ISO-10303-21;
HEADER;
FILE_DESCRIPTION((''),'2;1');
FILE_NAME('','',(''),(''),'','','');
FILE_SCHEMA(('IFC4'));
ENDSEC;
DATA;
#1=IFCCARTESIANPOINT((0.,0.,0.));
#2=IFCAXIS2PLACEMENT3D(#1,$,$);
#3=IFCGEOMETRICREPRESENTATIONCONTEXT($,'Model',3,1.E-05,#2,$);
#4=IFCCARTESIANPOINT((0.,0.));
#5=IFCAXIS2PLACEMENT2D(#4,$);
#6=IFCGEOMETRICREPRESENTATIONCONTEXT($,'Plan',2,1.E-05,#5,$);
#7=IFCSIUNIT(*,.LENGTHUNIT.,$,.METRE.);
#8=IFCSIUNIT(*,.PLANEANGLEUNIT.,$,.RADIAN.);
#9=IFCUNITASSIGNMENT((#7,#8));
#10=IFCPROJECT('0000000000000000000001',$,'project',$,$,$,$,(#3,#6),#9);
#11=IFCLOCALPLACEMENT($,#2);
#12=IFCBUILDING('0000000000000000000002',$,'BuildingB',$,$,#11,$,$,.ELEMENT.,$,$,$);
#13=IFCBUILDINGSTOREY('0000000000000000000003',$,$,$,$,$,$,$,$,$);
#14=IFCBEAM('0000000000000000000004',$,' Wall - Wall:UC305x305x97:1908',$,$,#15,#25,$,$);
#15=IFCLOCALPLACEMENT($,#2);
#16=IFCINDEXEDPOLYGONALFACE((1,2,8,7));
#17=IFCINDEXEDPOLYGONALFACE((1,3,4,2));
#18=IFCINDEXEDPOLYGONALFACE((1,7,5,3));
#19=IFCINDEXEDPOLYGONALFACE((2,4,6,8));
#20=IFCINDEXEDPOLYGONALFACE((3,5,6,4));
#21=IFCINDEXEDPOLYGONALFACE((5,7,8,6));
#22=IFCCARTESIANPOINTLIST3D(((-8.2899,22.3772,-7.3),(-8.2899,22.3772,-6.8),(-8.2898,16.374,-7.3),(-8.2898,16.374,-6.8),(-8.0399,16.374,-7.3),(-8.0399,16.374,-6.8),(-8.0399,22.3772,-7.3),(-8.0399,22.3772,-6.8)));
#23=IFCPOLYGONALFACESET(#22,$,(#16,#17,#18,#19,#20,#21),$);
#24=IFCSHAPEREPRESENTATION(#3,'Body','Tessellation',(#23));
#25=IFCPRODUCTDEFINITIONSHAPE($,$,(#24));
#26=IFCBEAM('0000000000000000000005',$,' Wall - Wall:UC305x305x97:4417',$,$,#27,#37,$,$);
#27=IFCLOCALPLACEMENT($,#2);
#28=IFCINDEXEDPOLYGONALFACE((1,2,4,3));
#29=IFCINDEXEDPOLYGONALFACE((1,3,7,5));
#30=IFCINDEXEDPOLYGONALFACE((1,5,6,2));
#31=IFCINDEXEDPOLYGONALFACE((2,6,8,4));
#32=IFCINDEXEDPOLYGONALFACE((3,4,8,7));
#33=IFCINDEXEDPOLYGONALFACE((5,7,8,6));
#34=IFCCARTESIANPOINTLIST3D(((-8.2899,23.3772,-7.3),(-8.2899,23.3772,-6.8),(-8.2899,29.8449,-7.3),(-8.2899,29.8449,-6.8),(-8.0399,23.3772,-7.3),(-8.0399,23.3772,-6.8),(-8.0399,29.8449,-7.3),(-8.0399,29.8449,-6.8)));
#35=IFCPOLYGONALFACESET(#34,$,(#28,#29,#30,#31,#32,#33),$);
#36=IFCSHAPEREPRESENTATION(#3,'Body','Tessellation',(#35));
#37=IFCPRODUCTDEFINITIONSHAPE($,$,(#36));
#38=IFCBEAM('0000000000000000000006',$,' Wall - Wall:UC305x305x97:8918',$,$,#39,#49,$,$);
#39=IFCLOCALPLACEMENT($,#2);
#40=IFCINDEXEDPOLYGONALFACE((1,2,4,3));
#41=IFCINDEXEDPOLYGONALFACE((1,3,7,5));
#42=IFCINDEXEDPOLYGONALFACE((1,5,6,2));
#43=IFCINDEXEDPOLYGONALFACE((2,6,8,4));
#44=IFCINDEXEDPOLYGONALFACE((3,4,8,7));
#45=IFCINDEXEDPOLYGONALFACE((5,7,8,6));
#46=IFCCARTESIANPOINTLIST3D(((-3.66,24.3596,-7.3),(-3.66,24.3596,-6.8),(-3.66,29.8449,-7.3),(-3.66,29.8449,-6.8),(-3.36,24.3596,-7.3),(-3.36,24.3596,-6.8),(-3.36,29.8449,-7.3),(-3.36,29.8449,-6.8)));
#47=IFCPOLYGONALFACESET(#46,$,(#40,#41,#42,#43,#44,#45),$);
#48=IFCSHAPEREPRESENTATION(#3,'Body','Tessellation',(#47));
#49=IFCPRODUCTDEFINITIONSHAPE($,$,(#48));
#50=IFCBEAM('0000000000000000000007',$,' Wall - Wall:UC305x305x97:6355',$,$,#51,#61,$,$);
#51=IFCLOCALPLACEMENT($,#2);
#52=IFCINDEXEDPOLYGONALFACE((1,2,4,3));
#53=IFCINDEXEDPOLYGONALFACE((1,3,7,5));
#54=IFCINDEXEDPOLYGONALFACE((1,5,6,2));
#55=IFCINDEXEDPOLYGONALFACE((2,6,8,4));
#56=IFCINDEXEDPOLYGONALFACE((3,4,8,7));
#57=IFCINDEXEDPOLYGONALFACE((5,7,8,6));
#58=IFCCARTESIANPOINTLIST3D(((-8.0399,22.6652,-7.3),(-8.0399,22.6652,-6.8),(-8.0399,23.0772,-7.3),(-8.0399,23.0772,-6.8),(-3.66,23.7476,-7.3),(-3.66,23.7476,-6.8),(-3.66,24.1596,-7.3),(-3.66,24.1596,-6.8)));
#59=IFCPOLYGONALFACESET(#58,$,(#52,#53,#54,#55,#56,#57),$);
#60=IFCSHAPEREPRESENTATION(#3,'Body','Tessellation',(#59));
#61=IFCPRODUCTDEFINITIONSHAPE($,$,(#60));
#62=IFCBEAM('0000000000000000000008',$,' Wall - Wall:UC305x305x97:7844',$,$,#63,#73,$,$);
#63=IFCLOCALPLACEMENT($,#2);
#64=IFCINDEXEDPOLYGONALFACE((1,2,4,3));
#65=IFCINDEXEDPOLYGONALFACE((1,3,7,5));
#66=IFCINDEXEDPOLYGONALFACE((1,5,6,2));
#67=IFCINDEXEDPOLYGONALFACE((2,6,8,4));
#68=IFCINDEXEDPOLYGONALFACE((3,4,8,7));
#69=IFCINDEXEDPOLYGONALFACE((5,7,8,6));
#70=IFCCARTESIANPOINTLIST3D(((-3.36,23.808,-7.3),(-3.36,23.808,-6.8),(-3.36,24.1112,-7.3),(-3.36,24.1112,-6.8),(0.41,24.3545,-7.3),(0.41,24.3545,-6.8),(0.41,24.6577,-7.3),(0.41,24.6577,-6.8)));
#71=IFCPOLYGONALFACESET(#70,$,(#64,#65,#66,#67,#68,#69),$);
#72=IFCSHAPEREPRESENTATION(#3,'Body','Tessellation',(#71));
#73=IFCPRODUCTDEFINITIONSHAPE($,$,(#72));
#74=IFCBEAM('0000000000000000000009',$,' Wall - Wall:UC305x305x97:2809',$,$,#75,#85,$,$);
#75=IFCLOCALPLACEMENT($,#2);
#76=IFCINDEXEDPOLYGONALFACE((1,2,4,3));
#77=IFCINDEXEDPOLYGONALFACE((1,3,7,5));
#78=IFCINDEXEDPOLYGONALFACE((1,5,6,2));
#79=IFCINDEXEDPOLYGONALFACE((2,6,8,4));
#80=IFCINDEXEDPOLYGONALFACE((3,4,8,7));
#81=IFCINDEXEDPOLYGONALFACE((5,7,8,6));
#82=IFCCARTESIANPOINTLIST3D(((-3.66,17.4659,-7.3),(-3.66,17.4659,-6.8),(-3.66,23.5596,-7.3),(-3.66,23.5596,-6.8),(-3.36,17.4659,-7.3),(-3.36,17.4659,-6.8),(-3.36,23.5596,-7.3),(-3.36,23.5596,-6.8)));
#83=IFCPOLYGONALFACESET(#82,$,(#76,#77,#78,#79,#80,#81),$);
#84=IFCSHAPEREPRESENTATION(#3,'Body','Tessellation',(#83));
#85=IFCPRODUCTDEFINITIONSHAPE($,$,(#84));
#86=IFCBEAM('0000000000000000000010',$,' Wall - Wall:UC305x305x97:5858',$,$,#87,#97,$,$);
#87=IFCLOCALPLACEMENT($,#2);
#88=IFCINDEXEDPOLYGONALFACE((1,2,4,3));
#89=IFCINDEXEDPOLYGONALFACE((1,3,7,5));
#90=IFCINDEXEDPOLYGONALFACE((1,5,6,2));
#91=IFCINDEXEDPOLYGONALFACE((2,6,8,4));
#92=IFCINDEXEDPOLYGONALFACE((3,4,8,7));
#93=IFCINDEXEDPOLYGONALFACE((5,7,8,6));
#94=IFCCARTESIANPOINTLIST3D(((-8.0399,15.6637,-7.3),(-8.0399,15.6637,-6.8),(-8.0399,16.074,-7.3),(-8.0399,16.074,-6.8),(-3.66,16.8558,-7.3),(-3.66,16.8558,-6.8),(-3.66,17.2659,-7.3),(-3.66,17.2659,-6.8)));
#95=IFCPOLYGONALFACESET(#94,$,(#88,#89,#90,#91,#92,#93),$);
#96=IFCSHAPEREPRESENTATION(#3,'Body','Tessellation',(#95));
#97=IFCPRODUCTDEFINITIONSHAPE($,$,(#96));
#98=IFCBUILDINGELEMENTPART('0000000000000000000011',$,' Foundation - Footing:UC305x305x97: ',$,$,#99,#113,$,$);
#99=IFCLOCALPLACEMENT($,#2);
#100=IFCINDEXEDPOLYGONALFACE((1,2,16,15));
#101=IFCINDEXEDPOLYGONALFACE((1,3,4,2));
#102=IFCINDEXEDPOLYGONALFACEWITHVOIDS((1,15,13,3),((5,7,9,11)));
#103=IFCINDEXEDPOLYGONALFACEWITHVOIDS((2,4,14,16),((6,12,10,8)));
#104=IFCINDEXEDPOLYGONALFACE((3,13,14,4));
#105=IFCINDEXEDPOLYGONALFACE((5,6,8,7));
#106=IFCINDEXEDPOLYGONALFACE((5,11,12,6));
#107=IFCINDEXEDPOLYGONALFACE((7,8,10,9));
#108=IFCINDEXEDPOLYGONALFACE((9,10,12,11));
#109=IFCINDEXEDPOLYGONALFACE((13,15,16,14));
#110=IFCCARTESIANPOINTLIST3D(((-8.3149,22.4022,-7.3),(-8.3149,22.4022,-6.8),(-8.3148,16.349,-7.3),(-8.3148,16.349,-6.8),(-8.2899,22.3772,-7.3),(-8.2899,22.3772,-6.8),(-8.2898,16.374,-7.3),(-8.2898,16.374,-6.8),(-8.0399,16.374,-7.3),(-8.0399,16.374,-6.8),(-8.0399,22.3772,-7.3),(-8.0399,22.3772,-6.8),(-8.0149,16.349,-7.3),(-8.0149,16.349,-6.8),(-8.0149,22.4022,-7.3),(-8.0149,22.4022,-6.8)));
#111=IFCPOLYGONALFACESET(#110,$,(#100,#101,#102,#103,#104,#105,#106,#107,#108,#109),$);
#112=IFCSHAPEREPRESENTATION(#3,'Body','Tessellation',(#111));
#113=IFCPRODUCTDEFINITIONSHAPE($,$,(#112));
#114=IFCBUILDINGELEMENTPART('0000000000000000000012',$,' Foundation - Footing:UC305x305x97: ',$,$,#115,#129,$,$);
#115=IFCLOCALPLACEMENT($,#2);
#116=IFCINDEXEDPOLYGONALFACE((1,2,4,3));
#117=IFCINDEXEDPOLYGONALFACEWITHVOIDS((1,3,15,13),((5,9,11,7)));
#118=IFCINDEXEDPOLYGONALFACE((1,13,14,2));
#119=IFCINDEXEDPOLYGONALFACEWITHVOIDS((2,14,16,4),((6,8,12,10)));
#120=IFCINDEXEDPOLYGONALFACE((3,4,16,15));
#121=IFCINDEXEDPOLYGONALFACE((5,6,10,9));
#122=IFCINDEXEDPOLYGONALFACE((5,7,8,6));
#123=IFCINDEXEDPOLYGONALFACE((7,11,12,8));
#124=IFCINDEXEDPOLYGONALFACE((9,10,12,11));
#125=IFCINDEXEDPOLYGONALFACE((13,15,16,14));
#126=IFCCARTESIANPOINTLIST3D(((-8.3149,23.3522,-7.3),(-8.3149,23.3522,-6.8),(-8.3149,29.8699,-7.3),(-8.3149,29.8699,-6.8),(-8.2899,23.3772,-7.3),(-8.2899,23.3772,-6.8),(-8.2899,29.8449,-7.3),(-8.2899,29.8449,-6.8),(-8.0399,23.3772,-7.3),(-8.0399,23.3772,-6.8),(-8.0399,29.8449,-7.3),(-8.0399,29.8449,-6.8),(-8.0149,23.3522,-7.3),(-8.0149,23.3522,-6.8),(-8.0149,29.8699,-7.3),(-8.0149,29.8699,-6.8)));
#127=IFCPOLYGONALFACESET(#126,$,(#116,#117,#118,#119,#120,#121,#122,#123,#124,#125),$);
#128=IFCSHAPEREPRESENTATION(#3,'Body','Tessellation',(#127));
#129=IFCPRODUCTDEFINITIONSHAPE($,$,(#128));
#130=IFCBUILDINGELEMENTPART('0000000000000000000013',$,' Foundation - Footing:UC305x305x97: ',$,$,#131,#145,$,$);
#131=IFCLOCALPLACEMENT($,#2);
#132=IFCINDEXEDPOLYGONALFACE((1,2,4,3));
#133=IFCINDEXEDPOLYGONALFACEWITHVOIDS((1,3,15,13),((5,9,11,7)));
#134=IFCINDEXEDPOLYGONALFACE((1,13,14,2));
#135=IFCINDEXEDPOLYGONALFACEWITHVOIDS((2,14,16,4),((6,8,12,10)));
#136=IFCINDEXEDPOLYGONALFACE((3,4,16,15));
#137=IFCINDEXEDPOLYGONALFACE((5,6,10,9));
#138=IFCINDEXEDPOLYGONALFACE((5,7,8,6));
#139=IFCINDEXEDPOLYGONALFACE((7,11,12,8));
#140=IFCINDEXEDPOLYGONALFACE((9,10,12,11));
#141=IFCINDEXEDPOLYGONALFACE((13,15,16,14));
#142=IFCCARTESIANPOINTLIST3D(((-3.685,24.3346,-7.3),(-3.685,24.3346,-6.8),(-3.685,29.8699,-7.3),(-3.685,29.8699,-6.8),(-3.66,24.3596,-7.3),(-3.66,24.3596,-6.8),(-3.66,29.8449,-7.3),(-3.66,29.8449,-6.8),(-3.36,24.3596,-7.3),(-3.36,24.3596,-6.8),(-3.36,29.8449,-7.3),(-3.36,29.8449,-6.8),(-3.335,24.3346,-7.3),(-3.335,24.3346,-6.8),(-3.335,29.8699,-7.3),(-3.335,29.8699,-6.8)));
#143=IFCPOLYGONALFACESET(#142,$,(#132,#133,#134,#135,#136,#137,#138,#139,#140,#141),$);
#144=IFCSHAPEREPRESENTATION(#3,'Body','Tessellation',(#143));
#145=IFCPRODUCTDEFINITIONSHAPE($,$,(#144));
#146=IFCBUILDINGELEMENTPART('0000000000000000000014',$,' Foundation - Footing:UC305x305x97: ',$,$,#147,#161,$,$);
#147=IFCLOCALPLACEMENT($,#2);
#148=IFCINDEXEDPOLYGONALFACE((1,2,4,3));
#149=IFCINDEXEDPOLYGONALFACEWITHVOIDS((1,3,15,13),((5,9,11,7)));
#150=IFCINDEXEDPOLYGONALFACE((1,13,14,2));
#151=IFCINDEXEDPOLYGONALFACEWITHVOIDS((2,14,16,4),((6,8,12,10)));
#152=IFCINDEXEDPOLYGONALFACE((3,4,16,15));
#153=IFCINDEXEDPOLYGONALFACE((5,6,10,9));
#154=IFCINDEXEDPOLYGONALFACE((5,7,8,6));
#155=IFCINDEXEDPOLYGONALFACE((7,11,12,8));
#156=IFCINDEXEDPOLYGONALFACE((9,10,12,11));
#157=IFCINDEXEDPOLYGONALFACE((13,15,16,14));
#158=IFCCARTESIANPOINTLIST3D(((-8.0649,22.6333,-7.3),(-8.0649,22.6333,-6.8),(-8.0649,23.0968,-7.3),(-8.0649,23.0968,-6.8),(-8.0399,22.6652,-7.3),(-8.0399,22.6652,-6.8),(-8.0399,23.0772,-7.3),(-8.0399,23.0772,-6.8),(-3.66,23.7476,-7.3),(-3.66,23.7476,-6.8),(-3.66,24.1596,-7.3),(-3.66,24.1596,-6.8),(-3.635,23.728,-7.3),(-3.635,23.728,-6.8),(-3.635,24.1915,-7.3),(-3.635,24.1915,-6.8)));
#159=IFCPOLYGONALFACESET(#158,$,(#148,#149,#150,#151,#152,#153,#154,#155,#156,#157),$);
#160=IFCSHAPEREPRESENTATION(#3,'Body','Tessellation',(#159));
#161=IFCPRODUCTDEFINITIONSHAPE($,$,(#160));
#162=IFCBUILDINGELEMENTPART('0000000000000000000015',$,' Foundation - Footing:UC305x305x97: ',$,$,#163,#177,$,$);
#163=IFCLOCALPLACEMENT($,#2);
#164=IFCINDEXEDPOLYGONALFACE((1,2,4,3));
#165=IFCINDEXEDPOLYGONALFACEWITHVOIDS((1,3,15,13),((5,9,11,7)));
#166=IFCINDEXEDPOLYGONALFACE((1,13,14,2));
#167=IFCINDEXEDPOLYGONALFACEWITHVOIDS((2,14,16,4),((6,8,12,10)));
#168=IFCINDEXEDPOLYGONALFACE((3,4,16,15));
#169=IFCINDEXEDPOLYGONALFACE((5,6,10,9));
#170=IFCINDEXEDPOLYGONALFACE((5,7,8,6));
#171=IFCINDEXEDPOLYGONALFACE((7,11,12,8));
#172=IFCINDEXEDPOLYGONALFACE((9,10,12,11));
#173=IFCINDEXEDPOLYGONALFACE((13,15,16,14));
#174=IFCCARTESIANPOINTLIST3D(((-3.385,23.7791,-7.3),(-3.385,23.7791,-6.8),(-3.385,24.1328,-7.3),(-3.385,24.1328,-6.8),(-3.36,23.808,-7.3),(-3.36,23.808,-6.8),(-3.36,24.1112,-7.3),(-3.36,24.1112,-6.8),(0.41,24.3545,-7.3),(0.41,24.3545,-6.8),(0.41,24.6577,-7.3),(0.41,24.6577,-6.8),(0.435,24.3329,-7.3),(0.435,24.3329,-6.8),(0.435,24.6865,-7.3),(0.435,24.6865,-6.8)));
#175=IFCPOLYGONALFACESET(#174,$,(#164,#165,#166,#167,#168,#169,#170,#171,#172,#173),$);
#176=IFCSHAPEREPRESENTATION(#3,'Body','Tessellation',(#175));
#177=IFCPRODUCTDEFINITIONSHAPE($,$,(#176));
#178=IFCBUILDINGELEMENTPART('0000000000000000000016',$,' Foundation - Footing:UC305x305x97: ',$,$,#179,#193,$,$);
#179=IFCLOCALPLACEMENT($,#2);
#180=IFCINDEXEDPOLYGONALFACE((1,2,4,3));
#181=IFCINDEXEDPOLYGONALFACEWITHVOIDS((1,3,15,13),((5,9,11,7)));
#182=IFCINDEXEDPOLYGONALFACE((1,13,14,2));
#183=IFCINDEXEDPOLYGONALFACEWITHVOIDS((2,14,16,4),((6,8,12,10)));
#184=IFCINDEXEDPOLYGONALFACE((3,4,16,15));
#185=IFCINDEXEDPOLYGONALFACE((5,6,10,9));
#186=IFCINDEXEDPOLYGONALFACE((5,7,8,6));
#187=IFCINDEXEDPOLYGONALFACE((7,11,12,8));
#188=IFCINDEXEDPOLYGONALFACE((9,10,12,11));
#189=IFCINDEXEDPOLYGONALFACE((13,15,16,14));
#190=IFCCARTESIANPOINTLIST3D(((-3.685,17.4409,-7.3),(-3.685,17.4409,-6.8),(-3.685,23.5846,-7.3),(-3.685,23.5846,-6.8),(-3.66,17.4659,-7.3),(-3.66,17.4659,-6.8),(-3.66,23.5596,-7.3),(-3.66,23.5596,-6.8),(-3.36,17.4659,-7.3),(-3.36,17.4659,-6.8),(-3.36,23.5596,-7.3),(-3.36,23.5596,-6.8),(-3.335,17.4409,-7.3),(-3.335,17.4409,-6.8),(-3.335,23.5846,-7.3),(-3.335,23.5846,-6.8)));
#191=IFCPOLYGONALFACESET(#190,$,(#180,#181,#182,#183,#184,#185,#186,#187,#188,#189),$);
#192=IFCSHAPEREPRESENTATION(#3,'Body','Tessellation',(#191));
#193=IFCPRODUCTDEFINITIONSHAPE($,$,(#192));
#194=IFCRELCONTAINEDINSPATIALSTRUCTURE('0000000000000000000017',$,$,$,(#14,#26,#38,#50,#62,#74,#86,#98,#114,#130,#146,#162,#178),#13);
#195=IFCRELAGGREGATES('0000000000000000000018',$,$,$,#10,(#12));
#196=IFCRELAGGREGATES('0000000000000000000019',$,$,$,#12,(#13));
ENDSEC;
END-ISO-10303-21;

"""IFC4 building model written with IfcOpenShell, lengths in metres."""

from ifc_helpers import new_model, si_unit, origin, origin_2d, place, context, project, spatial, polyline, outline, extrude, element, save


model = new_model("IFC4")

# Units and contexts
model_context = context("Model", 3, precision=1e-05, world=origin())
plan_context = context("Plan", 2, precision=1e-05, world=origin_2d())
ifc_project = project(units=[si_unit("LENGTHUNIT", "METRE"), si_unit("PLANEANGLEUNIT", "RADIAN")], contexts=[model_context, plan_context])

# Building, storey
building_placement = place(None, origin())
building = spatial("IfcBuilding", under=ifc_project, at=building_placement, Name="BuildingB", CompositionType="ELEMENT")
storey = spatial("IfcBuildingStorey", under=building)

# Beams
element("IfcBeam", 1, inside=storey, Name=" Wall - Wall:UC305x305x97:1908", context=model_context, shape_type="SweptSolid", body=[
    extrude(outline(polyline([(-8.2898, 16.374, -7.3), (-8.0399, 16.374, -7.3), (-8.0399, 22.3772, -7.3), (-8.2899, 22.3772, -7.3), (-8.2898, 16.374, -7.3)])), None, (0.0, 0.0, 1.0), 0.5),
])
element("IfcBeam", 2, inside=storey, Name=" Wall - Wall:UC305x305x97:4417", context=model_context, shape_type="SweptSolid", body=[
    extrude(outline(polyline([(-8.2899, 23.3772, -7.3), (-8.0399, 23.3772, -7.3), (-8.0399, 29.8449, -7.3), (-8.2899, 29.8449, -7.3), (-8.2899, 23.3772, -7.3)])), None, (0.0, 0.0, 1.0), 0.5),
])
element("IfcBeam", 3, inside=storey, Name=" Wall - Wall:UC305x305x97:8918", context=model_context, shape_type="SweptSolid", body=[
    extrude(outline(polyline([(-3.66, 29.8449, -7.3), (-3.36, 29.8449, -7.3), (-3.36, 24.3596, -7.3), (-3.66, 24.3596, -7.3), (-3.66, 29.8449, -7.3)])), None, (0.0, 0.0, 1.0), 0.5),
])
element("IfcBeam", 4, inside=storey, Name=" Wall - Wall:UC305x305x97:6355", context=model_context, shape_type="SweptSolid", body=[
    extrude(outline(polyline([(-3.66, 24.1596, -7.3), (-3.66, 23.7476, -7.3), (-8.0399, 22.6652, -7.3), (-8.0399, 23.0772, -7.3), (-3.66, 24.1596, -7.3)])), None, (0.0, 0.0, 1.0), 0.5),
])
element("IfcBeam", 5, inside=storey, Name=" Wall - Wall:UC305x305x97:7844", context=model_context, shape_type="SweptSolid", body=[
    extrude(outline(polyline([(-3.36, 23.808, -7.3), (0.41, 24.3545, -7.3), (0.41, 24.6577, -7.3), (-3.36, 24.1112, -7.3), (-3.36, 23.808, -7.3)])), None, (0.0, 0.0, 1.0), 0.5),
])
element("IfcBeam", 6, inside=storey, Name=" Wall - Wall:UC305x305x97:2809", context=model_context, shape_type="SweptSolid", body=[
    extrude(outline(polyline([(-3.66, 23.5596, -7.3), (-3.36, 23.5596, -7.3), (-3.36, 17.4659, -7.3), (-3.66, 17.4659, -7.3), (-3.66, 23.5596, -7.3)])), None, (0.0, 0.0, 1.0), 0.5),
])
element("IfcBeam", 7, inside=storey, Name=" Wall - Wall:UC305x305x97:5858", context=model_context, shape_type="SweptSolid", body=[
    extrude(outline(polyline([(-8.0399, 15.6637, -7.3), (-8.0399, 16.074, -7.3), (-3.66, 17.2659, -7.3), (-3.66, 16.8558, -7.3), (-8.0399, 15.6637, -7.3)])), None, (0.0, 0.0, 1.0), 0.5),
])

# Building element parts, openings
building_element_part_1 = element("IfcBuildingElementPart", 8, inside=storey, Name=" Foundation - Footing:UC305x305x97: ", context=model_context, shape_type="SweptSolid", body=[
    extrude(outline(polyline([(-8.3148, 16.349, -7.3), (-8.0149, 16.349, -7.3), (-8.0149, 22.4022, -7.3), (-8.3149, 22.4022, -7.3), (-8.3148, 16.349, -7.3)])), None, (0.0, 0.0, 1.0), 0.5),
])
element("IfcOpeningElement", 9, inside=storey, cuts=building_element_part_1, context=model_context, shape_type="SweptSolid", body=[
    extrude(outline(polyline([(-8.2898, 16.374, -7.3), (-8.0399, 16.374, -7.3), (-8.0399, 22.3772, -7.3), (-8.2899, 22.3772, -7.3), (-8.2898, 16.374, -7.3)])), None, (0.0, 0.0, 1.0), 0.5),
])
building_element_part_2 = element("IfcBuildingElementPart", 10, inside=storey, Name=" Foundation - Footing:UC305x305x97: ", context=model_context, shape_type="SweptSolid", body=[
    extrude(outline(polyline([(-8.3149, 23.3522, -7.3), (-8.0149, 23.3522, -7.3), (-8.0149, 29.8699, -7.3), (-8.3149, 29.8699, -7.3), (-8.3149, 23.3522, -7.3)])), None, (0.0, 0.0, 1.0), 0.5),
])
element("IfcOpeningElement", 11, inside=storey, cuts=building_element_part_2, context=model_context, shape_type="SweptSolid", body=[
    extrude(outline(polyline([(-8.2899, 23.3772, -7.3), (-8.0399, 23.3772, -7.3), (-8.0399, 29.8449, -7.3), (-8.2899, 29.8449, -7.3), (-8.2899, 23.3772, -7.3)])), None, (0.0, 0.0, 1.0), 0.5),
])
building_element_part_3 = element("IfcBuildingElementPart", 12, inside=storey, Name=" Foundation - Footing:UC305x305x97: ", context=model_context, shape_type="SweptSolid", body=[
    extrude(outline(polyline([(-3.685, 29.8699, -7.3), (-3.335, 29.8699, -7.3), (-3.335, 24.3346, -7.3), (-3.685, 24.3346, -7.3), (-3.685, 29.8699, -7.3)])), None, (0.0, 0.0, 1.0), 0.5),
])
element("IfcOpeningElement", 13, inside=storey, cuts=building_element_part_3, context=model_context, shape_type="SweptSolid", body=[
    extrude(outline(polyline([(-3.66, 29.8449, -7.3), (-3.36, 29.8449, -7.3), (-3.36, 24.3596, -7.3), (-3.66, 24.3596, -7.3), (-3.66, 29.8449, -7.3)])), None, (0.0, 0.0, 1.0), 0.5),
])
building_element_part_4 = element("IfcBuildingElementPart", 14, inside=storey, Name=" Foundation - Footing:UC305x305x97: ", context=model_context, shape_type="SweptSolid", body=[
    extrude(outline(polyline([(-3.635, 24.1915, -7.3), (-3.635, 23.728, -7.3), (-8.0649, 22.6333, -7.3), (-8.0649, 23.0968, -7.3), (-3.635, 24.1915, -7.3)])), None, (0.0, 0.0, 1.0), 0.5),
])
element("IfcOpeningElement", 15, inside=storey, cuts=building_element_part_4, context=model_context, shape_type="SweptSolid", body=[
    extrude(outline(polyline([(-3.66, 24.1596, -7.3), (-3.66, 23.7476, -7.3), (-8.0399, 22.6652, -7.3), (-8.0399, 23.0772, -7.3), (-3.66, 24.1596, -7.3)])), None, (0.0, 0.0, 1.0), 0.5),
])
building_element_part_5 = element("IfcBuildingElementPart", 16, inside=storey, Name=" Foundation - Footing:UC305x305x97: ", context=model_context, shape_type="SweptSolid", body=[
    extrude(outline(polyline([(-3.385, 23.7791, -7.3), (0.435, 24.3329, -7.3), (0.435, 24.6865, -7.3), (-3.385, 24.1328, -7.3), (-3.385, 23.7791, -7.3)])), None, (0.0, 0.0, 1.0), 0.5),
])
element("IfcOpeningElement", 17, inside=storey, cuts=building_element_part_5, context=model_context, shape_type="SweptSolid", body=[
    extrude(outline(polyline([(-3.36, 23.808, -7.3), (0.41, 24.3545, -7.3), (0.41, 24.6577, -7.3), (-3.36, 24.1112, -7.3), (-3.36, 23.808, -7.3)])), None, (0.0, 0.0, 1.0), 0.5),
])
building_element_part_6 = element("IfcBuildingElementPart", 18, inside=storey, Name=" Foundation - Footing:UC305x305x97: ", context=model_context, shape_type="SweptSolid", body=[
    extrude(outline(polyline([(-3.685, 23.5846, -7.3), (-3.335, 23.5846, -7.3), (-3.335, 17.4409, -7.3), (-3.685, 17.4409, -7.3), (-3.685, 23.5846, -7.3)])), None, (0.0, 0.0, 1.0), 0.5),
])
element("IfcOpeningElement", 19, inside=storey, cuts=building_element_part_6, context=model_context, shape_type="SweptSolid", body=[
    extrude(outline(polyline([(-3.66, 23.5596, -7.3), (-3.36, 23.5596, -7.3), (-3.36, 17.4659, -7.3), (-3.66, 17.4659, -7.3), (-3.66, 23.5596, -7.3)])), None, (0.0, 0.0, 1.0), 0.5),
])

save(model, "model.ifc")
